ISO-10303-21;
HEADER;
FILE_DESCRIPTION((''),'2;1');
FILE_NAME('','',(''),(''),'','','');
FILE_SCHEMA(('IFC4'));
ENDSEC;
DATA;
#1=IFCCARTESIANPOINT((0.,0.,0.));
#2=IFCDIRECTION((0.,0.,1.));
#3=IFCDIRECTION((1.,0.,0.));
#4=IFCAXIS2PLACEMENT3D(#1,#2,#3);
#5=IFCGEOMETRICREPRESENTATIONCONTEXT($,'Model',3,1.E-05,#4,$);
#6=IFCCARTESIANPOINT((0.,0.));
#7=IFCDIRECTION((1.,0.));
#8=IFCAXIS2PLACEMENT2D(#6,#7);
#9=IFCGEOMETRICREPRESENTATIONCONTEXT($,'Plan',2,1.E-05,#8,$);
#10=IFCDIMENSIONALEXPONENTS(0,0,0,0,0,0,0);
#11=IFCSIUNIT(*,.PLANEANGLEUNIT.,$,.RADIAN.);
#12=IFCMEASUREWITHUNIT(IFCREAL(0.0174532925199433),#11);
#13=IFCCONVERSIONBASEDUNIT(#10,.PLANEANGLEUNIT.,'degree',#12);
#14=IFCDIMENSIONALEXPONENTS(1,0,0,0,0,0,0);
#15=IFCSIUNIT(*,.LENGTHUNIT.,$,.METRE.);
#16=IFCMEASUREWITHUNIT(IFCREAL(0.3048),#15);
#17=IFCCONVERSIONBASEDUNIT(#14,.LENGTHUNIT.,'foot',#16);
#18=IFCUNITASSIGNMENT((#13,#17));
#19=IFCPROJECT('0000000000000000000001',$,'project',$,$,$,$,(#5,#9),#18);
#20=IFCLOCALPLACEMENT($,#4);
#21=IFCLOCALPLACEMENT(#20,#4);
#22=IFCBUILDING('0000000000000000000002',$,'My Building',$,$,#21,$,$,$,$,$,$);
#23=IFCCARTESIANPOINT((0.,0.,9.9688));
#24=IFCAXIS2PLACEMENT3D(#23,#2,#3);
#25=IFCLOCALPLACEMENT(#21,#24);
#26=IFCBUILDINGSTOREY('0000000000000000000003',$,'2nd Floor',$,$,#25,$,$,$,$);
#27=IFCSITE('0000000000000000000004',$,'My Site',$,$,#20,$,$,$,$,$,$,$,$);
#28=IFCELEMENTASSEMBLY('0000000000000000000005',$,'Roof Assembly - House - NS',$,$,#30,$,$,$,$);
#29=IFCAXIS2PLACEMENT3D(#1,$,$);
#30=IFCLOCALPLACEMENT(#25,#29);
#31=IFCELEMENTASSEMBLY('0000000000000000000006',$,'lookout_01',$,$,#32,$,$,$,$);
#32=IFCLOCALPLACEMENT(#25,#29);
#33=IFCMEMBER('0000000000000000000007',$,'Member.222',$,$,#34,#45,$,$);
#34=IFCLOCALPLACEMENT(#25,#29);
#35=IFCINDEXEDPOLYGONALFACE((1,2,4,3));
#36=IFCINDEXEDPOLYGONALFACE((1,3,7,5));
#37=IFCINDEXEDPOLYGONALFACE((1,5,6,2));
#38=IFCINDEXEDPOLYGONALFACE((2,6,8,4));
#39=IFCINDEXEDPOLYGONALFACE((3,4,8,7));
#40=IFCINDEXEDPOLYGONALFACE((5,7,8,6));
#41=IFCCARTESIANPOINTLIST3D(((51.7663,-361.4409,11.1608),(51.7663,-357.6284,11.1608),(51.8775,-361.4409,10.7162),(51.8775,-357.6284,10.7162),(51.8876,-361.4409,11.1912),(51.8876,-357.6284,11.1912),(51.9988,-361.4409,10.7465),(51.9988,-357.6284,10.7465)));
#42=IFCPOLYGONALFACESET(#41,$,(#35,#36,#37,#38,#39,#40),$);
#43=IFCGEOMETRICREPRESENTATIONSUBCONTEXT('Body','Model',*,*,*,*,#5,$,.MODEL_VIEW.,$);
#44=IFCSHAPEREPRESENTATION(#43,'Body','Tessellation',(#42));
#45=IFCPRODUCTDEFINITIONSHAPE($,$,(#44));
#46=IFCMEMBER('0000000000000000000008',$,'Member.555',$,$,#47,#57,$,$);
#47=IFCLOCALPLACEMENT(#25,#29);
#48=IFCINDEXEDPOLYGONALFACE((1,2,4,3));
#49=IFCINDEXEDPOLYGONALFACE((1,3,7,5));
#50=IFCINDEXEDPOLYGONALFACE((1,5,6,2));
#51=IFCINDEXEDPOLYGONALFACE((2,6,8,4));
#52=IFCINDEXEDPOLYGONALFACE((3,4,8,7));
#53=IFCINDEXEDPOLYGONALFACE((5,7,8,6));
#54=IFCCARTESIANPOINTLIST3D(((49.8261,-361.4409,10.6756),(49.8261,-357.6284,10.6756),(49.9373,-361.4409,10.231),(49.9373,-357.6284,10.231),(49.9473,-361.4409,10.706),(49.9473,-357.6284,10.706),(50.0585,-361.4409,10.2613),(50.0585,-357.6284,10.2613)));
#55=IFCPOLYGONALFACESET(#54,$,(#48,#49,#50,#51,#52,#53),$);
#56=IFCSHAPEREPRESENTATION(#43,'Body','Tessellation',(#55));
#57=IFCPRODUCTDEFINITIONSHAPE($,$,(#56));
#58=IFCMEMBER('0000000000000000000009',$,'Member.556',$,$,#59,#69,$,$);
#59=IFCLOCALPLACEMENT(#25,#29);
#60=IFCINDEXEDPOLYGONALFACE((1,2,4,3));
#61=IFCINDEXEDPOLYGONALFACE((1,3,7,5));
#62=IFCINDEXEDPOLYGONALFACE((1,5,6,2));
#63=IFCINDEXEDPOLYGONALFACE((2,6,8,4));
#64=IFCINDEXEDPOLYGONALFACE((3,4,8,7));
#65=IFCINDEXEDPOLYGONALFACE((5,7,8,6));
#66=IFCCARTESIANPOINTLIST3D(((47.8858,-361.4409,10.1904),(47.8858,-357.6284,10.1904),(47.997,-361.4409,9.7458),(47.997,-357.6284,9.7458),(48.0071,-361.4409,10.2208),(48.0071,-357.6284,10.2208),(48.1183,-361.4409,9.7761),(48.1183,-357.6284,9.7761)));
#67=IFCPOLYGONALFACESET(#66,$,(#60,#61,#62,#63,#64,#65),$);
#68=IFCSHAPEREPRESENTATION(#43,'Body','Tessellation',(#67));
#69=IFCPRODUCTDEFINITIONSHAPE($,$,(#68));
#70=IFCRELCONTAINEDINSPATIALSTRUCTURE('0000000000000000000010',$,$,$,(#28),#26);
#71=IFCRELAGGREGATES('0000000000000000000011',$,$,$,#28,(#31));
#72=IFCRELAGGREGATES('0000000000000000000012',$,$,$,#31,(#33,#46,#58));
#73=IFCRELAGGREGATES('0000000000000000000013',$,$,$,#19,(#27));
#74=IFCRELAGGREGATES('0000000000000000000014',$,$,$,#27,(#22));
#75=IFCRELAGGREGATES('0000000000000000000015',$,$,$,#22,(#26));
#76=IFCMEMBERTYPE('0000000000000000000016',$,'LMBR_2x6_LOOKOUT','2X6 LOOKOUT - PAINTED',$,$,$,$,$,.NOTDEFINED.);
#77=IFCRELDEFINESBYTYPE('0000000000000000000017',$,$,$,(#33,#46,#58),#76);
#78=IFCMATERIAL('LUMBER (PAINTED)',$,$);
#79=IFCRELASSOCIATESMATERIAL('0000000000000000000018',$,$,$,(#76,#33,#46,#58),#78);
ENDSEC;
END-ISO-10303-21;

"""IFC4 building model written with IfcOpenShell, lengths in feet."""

from ifc_helpers import new_model, entity, si_unit, converted_unit, frame, origin_with_axes, origin_2d_with_axis, place, context, subcontext, project, spatial, indexed_curve, outline, extrude, material, material_profile, profile_set, profile_usage, type_object, element, aggregate, save


model = new_model("IFC4")

# Units and contexts
model_context = context("Model", 3, precision=1e-05, world=origin_with_axes())
plan_context = context("Plan", 2, precision=1e-05, world=origin_2d_with_axis())
body_context = subcontext(model_context, "Body", "Model", "MODEL_VIEW")
ifc_project = project(units=[converted_unit("PLANEANGLEUNIT", "degree", entity("IfcReal", 0.0174532925199433), si_unit("PLANEANGLEUNIT", "RADIAN"), dimensions=[0, 0, 0, 0, 0, 0, 0]), converted_unit("LENGTHUNIT", "foot", entity("IfcReal", 0.3048), si_unit("LENGTHUNIT", "METRE"), dimensions=[1, 0, 0, 0, 0, 0, 0])], contexts=[model_context, plan_context])

# Site, building, storey
site_placement = place(None, origin_with_axes())
site = spatial("IfcSite", under=ifc_project, at=site_placement, Name="My Site")
building_placement = place(site_placement, origin_with_axes())
building = spatial("IfcBuilding", under=site, at=building_placement, Name="My Building")
storey_placement = place(building_placement, frame((0.0, 0.0, 9.9688), z_axis=(0.0, 0.0, 1.0), x_axis=(1.0, 0.0, 0.0)))
storey = spatial("IfcBuildingStorey", under=building, at=storey_placement, Name="2nd Floor")

# Element assemblies, members
assembly_1_placement = place(storey_placement, frame((0.0, 0.0, -9.9688), z_axis=(0.0, 0.0, 1.0), x_axis=(1.0, 0.0, 0.0)))
assembly_1 = element("IfcElementAssembly", 1, at=assembly_1_placement, inside=storey, Name="Roof Assembly - House - NS")
ifc_material = material(Name="LUMBER (PAINTED)")
assembly_2_placement = place(assembly_1_placement, frame((53.6914, -361.5034, 21.6754), z_axis=(0.0, 0.0, 1.0), x_axis=(1.0, 0.0, 0.0)))
assembly_2 = element("IfcElementAssembly", 2, at=assembly_2_placement, Name="lookout_01")
aggregate(assembly_1, [assembly_2])
ifc_material_profile_1 = material_profile(ifc_material, outline(indexed_curve([(-0.0625, 0.2292), (0.0625, 0.2292), (0.0625, -0.2292), (-0.0625, -0.2292), (-0.0625, 0.2292)])))
ifc_profile_set_1 = profile_set([ifc_material_profile_1])
ifc_profile_usage_1 = profile_usage(ifc_profile_set_1)
member_type_1 = type_object("IfcMemberType", Name="LMBR_2x6_LOOKOUT", Description="2X6 LOOKOUT - PAINTED", PredefinedType="NOTDEFINED", material=ifc_profile_set_1)
member_1_placement = place(assembly_2_placement, frame((-1.8089, 0.0625, -0.753), z_axis=(0.0, 1.0, 0.0), x_axis=(-0.970127, 0.0, -0.242599)))
member_1 = element("IfcMember", 3, at=member_1_placement, type_object=member_type_1, material=ifc_profile_usage_1, Name="Member.222", context=body_context, shape_type="SweptSolid", body=[
    extrude(outline(indexed_curve([(-0.0625, 0.2292), (0.0625, 0.2292), (0.0625, -0.2292), (-0.0625, -0.2292), (-0.0625, 0.2292)])), origin_with_axes(), (0.0, 0.0, 1.0), 3.8125),
])
ifc_profile_usage_2 = profile_usage(ifc_profile_set_1)
member_2_placement = place(assembly_2_placement, frame((-3.7491, 0.0625, -1.2382), z_axis=(0.0, 1.0, 0.0), x_axis=(-0.970127, 0.0, -0.242599)))
member_2 = element("IfcMember", 4, at=member_2_placement, type_object=member_type_1, material=ifc_profile_usage_2, Name="Member.555", context=body_context, shape_type="SweptSolid", body=[
    extrude(outline(indexed_curve([(-0.0625, 0.2292), (0.0625, 0.2292), (0.0625, -0.2292), (-0.0625, -0.2292), (-0.0625, 0.2292)])), origin_with_axes(), (0.0, 0.0, 1.0), 3.8125),
])
ifc_profile_usage_3 = profile_usage(ifc_profile_set_1)
member_3_placement = place(assembly_2_placement, frame((-5.6894, 0.0625, -1.7234), z_axis=(0.0, 1.0, 0.0), x_axis=(-0.970127, 0.0, -0.242599)))
member_3 = element("IfcMember", 5, at=member_3_placement, type_object=member_type_1, material=ifc_profile_usage_3, Name="Member.556", context=body_context, shape_type="SweptSolid", body=[
    extrude(outline(indexed_curve([(-0.0625, 0.2292), (0.0625, 0.2292), (0.0625, -0.2292), (-0.0625, -0.2292), (-0.0625, 0.2292)])), origin_with_axes(), (0.0, 0.0, 1.0), 3.8125),
])
aggregate(assembly_2, [member_1, member_2, member_3])

save(model, "model.ifc")
